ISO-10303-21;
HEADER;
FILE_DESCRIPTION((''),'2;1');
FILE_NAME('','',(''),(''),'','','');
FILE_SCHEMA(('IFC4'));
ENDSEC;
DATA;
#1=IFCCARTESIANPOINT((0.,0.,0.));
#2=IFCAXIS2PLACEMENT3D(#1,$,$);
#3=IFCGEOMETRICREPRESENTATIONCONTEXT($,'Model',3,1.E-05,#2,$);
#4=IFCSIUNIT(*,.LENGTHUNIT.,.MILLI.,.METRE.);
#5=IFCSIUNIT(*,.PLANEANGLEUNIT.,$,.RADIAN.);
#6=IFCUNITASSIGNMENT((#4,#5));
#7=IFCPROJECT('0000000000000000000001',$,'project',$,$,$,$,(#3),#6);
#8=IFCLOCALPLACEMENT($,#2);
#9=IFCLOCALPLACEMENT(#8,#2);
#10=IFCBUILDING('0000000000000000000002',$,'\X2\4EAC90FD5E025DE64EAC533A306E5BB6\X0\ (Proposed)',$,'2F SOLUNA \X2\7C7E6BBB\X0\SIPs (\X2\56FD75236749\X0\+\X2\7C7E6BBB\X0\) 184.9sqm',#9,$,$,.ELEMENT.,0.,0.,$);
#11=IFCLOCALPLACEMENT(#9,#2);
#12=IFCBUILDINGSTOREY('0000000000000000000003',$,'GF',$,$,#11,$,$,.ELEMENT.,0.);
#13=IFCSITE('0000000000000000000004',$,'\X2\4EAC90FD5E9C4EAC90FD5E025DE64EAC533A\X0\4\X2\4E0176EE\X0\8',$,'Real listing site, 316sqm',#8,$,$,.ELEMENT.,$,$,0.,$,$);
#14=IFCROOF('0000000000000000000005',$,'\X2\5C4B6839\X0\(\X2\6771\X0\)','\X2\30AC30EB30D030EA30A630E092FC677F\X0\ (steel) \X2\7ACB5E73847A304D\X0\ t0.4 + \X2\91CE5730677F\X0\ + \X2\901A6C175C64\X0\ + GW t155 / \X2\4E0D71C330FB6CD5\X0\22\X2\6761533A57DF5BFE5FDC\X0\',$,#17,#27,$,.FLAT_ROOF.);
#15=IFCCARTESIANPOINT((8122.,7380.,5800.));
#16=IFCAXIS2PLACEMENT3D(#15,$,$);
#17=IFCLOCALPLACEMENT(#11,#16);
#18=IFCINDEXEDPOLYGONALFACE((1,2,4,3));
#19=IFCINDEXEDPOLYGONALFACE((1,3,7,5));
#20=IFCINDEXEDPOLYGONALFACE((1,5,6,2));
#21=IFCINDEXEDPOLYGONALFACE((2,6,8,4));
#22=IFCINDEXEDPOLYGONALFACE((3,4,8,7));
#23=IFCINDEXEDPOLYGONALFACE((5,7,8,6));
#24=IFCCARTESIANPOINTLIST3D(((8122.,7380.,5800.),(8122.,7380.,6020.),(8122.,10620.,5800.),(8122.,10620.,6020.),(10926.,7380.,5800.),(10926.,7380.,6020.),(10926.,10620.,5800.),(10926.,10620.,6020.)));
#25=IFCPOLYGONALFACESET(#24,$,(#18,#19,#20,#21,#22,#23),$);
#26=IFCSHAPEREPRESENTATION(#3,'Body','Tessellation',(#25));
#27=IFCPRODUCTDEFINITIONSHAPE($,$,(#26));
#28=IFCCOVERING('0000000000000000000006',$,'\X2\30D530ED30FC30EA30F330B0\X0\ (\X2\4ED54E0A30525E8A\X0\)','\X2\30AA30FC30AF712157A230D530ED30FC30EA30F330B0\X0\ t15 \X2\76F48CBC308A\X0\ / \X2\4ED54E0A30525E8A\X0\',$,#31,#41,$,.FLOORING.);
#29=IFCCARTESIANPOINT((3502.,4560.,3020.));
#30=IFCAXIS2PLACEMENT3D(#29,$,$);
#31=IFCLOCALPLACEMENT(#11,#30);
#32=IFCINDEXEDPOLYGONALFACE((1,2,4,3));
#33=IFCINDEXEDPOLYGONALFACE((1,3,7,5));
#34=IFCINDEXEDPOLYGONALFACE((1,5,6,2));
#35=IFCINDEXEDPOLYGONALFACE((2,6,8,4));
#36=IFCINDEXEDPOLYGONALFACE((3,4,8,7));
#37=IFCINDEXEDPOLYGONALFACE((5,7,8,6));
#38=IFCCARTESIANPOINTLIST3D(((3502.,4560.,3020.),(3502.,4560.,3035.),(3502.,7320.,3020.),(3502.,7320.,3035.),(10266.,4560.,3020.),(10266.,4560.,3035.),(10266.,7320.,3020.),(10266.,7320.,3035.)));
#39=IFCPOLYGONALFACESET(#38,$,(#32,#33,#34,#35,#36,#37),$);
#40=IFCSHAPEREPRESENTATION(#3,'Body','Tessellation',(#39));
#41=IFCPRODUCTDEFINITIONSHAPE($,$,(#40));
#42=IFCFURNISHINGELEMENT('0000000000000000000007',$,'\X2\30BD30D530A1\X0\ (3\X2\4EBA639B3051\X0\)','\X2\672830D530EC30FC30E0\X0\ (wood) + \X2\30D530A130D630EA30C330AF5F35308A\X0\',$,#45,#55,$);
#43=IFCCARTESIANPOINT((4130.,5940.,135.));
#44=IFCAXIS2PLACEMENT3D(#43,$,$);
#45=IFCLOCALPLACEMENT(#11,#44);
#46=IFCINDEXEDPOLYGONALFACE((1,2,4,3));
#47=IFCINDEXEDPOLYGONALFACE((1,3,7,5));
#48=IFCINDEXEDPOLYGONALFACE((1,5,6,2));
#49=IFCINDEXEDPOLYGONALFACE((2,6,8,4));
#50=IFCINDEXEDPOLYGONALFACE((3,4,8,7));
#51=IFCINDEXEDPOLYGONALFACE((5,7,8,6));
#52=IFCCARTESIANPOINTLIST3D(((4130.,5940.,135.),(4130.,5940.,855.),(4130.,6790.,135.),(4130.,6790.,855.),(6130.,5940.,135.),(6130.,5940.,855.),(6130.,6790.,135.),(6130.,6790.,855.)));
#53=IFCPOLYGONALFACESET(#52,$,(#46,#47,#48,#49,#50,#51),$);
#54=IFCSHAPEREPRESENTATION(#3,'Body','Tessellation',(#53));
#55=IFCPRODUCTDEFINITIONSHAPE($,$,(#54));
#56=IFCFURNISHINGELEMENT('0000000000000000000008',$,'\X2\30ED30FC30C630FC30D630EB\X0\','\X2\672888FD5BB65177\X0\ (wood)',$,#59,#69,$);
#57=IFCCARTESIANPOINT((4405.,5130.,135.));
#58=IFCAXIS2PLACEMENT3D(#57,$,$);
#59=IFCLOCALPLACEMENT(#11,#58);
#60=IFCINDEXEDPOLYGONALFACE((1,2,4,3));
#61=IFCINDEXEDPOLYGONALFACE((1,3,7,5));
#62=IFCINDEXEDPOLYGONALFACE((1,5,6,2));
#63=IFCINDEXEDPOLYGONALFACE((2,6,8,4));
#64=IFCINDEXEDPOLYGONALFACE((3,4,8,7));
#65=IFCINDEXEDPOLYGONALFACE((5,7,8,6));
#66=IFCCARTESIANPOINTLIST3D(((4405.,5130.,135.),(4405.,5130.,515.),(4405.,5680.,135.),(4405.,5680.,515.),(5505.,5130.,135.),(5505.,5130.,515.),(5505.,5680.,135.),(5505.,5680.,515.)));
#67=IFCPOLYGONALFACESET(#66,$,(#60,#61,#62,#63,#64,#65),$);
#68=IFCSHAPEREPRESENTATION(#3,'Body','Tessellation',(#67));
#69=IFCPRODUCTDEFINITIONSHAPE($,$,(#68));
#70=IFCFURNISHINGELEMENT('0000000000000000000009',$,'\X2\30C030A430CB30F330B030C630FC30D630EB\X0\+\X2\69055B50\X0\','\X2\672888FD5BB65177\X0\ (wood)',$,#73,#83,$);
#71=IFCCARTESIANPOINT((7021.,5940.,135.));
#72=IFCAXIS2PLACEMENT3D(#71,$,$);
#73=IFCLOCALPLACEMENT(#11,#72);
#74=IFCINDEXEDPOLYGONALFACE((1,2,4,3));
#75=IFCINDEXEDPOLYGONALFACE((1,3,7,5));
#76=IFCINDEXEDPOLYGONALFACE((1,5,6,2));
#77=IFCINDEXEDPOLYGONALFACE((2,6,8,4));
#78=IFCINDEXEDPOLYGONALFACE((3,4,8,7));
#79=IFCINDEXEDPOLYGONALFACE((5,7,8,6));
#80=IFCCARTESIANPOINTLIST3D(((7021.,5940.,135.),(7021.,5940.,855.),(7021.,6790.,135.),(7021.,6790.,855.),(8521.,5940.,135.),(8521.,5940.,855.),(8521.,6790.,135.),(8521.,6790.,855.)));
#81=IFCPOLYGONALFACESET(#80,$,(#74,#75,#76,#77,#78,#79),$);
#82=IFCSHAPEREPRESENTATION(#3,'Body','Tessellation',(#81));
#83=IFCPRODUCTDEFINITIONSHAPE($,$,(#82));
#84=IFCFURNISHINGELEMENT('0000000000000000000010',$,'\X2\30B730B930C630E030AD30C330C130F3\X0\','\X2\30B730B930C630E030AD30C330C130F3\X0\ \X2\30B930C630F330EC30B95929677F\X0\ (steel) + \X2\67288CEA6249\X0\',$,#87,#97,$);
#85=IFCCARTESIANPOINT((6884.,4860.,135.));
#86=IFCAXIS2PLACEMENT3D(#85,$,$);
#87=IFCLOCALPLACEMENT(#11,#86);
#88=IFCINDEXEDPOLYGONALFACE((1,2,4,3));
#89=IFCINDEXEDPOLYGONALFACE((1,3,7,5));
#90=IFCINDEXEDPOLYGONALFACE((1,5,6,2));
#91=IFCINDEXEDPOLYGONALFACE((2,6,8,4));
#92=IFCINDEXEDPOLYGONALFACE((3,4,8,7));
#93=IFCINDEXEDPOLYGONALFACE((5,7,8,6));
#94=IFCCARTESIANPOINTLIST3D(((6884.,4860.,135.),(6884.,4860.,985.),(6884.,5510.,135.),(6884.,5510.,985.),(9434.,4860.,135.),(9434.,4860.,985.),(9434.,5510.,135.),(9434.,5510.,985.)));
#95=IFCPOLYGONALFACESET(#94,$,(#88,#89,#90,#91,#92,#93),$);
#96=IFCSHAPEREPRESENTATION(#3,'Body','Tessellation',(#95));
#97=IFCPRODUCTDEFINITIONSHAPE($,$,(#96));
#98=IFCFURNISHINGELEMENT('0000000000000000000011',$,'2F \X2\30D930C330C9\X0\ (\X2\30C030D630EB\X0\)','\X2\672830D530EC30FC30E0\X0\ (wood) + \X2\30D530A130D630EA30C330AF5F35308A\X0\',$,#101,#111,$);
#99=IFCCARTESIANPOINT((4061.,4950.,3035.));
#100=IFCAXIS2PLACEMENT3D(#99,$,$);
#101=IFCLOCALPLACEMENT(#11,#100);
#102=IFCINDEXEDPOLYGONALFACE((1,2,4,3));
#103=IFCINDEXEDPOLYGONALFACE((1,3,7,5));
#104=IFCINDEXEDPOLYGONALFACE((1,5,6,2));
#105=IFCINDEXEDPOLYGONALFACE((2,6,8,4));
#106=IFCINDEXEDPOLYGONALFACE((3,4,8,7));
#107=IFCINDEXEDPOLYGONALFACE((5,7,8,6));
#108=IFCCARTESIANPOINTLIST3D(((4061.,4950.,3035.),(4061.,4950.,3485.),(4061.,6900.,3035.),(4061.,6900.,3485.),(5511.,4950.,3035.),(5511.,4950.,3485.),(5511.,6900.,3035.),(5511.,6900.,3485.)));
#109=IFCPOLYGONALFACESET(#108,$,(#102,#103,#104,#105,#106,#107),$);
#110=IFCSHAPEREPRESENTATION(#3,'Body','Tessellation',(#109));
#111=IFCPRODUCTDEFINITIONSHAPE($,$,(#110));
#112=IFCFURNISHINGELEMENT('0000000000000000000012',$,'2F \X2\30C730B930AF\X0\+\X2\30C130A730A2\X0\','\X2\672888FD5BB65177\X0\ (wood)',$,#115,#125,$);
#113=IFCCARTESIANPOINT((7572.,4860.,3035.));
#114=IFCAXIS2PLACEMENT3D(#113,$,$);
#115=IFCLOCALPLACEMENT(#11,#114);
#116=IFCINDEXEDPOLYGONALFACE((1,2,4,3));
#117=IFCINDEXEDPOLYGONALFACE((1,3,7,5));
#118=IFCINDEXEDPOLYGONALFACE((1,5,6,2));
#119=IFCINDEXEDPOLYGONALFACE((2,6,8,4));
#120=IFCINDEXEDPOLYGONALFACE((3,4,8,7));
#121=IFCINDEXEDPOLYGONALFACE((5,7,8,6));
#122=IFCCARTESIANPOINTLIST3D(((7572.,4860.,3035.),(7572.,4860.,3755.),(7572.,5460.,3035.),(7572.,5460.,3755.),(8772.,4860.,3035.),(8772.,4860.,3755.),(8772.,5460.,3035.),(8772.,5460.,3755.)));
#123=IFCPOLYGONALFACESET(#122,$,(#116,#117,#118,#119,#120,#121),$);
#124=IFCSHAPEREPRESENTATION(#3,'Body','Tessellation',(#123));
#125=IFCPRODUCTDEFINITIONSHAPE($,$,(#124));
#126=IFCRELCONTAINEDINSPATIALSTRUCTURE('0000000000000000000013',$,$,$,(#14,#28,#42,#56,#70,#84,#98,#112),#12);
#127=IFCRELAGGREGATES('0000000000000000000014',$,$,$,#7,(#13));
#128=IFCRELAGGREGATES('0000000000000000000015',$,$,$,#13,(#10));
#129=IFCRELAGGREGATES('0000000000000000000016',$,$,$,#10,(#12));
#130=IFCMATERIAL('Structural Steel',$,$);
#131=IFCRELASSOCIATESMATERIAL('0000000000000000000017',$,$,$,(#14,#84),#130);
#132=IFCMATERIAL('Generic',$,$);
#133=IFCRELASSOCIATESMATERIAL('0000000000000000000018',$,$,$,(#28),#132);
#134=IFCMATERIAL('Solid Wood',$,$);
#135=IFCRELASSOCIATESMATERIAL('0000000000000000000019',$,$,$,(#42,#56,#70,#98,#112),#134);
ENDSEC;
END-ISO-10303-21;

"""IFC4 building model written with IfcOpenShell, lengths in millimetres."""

from ifc_helpers import new_model, si_unit, frame, frame_2d, origin, place, context, project, spatial, rectangle, extrude, material, element, save


model = new_model("IFC4")

# Units and contexts
model_context = context("Model", 3, precision=1e-05, world=origin())
ifc_project = project(units=[si_unit("LENGTHUNIT", "METRE", prefix="MILLI"), si_unit("PLANEANGLEUNIT", "RADIAN")], contexts=[model_context])

# Site, building, storey
site_placement = place(None, origin())
site = spatial("IfcSite", under=ifc_project, at=site_placement, Name="京都府京都市左京区4丁目8", ObjectType="Real listing site, 316sqm", CompositionType="ELEMENT", RefElevation=0.0)
building_placement = place(site_placement, origin())
building = spatial("IfcBuilding", under=site, at=building_placement, Name="京都市左京区の家 (Proposed)", ObjectType="2F SOLUNA 籾殻SIPs (国産杉+籾殻) 184.9sqm", CompositionType="ELEMENT", ElevationOfRefHeight=0.0, ElevationOfTerrain=0.0)
storey_placement = place(building_placement, origin())
storey = spatial("IfcBuildingStorey", under=building, at=storey_placement, Name="GF", CompositionType="ELEMENT", Elevation=0.0)

# Shared definitions
ifc_material_1 = material(Name="Solid Wood")

# Shared definitions
ifc_material_2 = material(Name="Generic")

# Roof
ifc_material_3 = material(Name="Structural Steel")
roof_placement = place(storey_placement, frame((8122.0, 7380.0, 5800.0)))
element("IfcRoof", 1, at=roof_placement, inside=storey, material=ifc_material_3, Name="屋根(東)", Description="ガルバリウム鋼板 (steel) 立平葺き t0.4 + 野地板 + 通気層 + GW t155 / 不燃・法22条区域対応", PredefinedType="FLAT_ROOF", context=model_context, shape_type="SweptSolid", body=[
    extrude(rectangle(XDim=2804.0, YDim=3240.0, at=frame_2d((1402.0, 1620.0))), frame((8122.0, 7380.0, 5800.0)), (0.0, 0.0, 1.0), 220.0),
])

# Covering
covering_placement = place(storey_placement, frame((3502.0, 4560.0, 3020.0)))
element("IfcCovering", 2, at=covering_placement, inside=storey, material=ifc_material_2, Name="フローリング (仕上げ床)", Description="オーク無垢フローリング t15 直貼り / 仕上げ床", PredefinedType="FLOORING", context=model_context, shape_type="SweptSolid", body=[
    extrude(rectangle(XDim=6764.0, YDim=2760.0, at=frame_2d((3382.0, 1380.0))), frame((3502.0, 4560.0, 3020.0)), (0.0, 0.0, 1.0), 15.0),
])

# Furnishing elements
furnishing_1_placement = place(storey_placement, frame((4130.0, 5940.0, 135.0)))
element("IfcFurnishingElement", 3, at=furnishing_1_placement, inside=storey, material=ifc_material_1, Name="ソファ (3人掛け)", Description="木フレーム (wood) + ファブリック張り", context=model_context, shape_type="SweptSolid", body=[
    extrude(rectangle(XDim=2000.0, YDim=850.0, at=frame_2d((1000.0, 425.0))), frame((4130.0, 5940.0, 135.0)), (0.0, 0.0, 1.0), 720.0),
])
furnishing_2_placement = place(storey_placement, frame((4405.0, 5130.0, 135.0)))
element("IfcFurnishingElement", 4, at=furnishing_2_placement, inside=storey, material=ifc_material_1, Name="ローテーブル", Description="木製家具 (wood)", context=model_context, shape_type="SweptSolid", body=[
    extrude(rectangle(XDim=1100.0, YDim=550.0, at=frame_2d((550.0, 275.0))), frame((4405.0, 5130.0, 135.0)), (0.0, 0.0, 1.0), 380.0),
])
furnishing_3_placement = place(storey_placement, frame((7021.0, 5940.0, 135.0)))
element("IfcFurnishingElement", 5, at=furnishing_3_placement, inside=storey, material=ifc_material_1, Name="ダイニングテーブル+椅子", Description="木製家具 (wood)", context=model_context, shape_type="SweptSolid", body=[
    extrude(rectangle(XDim=1500.0, YDim=850.0, at=frame_2d((750.0, 425.0))), frame((7021.0, 5940.0, 135.0)), (0.0, 0.0, 1.0), 720.0),
])
furnishing_4_placement = place(storey_placement, frame((6884.0, 4860.0, 135.0)))
element("IfcFurnishingElement", 6, at=furnishing_4_placement, inside=storey, material=ifc_material_3, Name="システムキッチン", Description="システムキッチン ステンレス天板 (steel) + 木質扉", context=model_context, shape_type="SweptSolid", body=[
    extrude(rectangle(XDim=2550.0, YDim=650.0, at=frame_2d((1275.0, 325.0))), frame((6884.0, 4860.0, 135.0)), (0.0, 0.0, 1.0), 850.0),
])
furnishing_5_placement = place(storey_placement, frame((4061.0, 4950.0, 3035.0)))
element("IfcFurnishingElement", 7, at=furnishing_5_placement, inside=storey, material=ifc_material_1, Name="2F ベッド (ダブル)", Description="木フレーム (wood) + ファブリック張り", context=model_context, shape_type="SweptSolid", body=[
    extrude(rectangle(XDim=1450.0, YDim=1950.0, at=frame_2d((725.0, 975.0))), frame((4061.0, 4950.0, 3035.0)), (0.0, 0.0, 1.0), 450.0),
])
furnishing_6_placement = place(storey_placement, frame((7572.0, 4860.0, 3035.0)))
element("IfcFurnishingElement", 8, at=furnishing_6_placement, inside=storey, material=ifc_material_1, Name="2F デスク+チェア", Description="木製家具 (wood)", context=model_context, shape_type="SweptSolid", body=[
    extrude(rectangle(XDim=1200.0, YDim=600.0, at=frame_2d((600.0, 300.0))), frame((7572.0, 4860.0, 3035.0)), (0.0, 0.0, 1.0), 720.0),
])

save(model, "model.ifc")
